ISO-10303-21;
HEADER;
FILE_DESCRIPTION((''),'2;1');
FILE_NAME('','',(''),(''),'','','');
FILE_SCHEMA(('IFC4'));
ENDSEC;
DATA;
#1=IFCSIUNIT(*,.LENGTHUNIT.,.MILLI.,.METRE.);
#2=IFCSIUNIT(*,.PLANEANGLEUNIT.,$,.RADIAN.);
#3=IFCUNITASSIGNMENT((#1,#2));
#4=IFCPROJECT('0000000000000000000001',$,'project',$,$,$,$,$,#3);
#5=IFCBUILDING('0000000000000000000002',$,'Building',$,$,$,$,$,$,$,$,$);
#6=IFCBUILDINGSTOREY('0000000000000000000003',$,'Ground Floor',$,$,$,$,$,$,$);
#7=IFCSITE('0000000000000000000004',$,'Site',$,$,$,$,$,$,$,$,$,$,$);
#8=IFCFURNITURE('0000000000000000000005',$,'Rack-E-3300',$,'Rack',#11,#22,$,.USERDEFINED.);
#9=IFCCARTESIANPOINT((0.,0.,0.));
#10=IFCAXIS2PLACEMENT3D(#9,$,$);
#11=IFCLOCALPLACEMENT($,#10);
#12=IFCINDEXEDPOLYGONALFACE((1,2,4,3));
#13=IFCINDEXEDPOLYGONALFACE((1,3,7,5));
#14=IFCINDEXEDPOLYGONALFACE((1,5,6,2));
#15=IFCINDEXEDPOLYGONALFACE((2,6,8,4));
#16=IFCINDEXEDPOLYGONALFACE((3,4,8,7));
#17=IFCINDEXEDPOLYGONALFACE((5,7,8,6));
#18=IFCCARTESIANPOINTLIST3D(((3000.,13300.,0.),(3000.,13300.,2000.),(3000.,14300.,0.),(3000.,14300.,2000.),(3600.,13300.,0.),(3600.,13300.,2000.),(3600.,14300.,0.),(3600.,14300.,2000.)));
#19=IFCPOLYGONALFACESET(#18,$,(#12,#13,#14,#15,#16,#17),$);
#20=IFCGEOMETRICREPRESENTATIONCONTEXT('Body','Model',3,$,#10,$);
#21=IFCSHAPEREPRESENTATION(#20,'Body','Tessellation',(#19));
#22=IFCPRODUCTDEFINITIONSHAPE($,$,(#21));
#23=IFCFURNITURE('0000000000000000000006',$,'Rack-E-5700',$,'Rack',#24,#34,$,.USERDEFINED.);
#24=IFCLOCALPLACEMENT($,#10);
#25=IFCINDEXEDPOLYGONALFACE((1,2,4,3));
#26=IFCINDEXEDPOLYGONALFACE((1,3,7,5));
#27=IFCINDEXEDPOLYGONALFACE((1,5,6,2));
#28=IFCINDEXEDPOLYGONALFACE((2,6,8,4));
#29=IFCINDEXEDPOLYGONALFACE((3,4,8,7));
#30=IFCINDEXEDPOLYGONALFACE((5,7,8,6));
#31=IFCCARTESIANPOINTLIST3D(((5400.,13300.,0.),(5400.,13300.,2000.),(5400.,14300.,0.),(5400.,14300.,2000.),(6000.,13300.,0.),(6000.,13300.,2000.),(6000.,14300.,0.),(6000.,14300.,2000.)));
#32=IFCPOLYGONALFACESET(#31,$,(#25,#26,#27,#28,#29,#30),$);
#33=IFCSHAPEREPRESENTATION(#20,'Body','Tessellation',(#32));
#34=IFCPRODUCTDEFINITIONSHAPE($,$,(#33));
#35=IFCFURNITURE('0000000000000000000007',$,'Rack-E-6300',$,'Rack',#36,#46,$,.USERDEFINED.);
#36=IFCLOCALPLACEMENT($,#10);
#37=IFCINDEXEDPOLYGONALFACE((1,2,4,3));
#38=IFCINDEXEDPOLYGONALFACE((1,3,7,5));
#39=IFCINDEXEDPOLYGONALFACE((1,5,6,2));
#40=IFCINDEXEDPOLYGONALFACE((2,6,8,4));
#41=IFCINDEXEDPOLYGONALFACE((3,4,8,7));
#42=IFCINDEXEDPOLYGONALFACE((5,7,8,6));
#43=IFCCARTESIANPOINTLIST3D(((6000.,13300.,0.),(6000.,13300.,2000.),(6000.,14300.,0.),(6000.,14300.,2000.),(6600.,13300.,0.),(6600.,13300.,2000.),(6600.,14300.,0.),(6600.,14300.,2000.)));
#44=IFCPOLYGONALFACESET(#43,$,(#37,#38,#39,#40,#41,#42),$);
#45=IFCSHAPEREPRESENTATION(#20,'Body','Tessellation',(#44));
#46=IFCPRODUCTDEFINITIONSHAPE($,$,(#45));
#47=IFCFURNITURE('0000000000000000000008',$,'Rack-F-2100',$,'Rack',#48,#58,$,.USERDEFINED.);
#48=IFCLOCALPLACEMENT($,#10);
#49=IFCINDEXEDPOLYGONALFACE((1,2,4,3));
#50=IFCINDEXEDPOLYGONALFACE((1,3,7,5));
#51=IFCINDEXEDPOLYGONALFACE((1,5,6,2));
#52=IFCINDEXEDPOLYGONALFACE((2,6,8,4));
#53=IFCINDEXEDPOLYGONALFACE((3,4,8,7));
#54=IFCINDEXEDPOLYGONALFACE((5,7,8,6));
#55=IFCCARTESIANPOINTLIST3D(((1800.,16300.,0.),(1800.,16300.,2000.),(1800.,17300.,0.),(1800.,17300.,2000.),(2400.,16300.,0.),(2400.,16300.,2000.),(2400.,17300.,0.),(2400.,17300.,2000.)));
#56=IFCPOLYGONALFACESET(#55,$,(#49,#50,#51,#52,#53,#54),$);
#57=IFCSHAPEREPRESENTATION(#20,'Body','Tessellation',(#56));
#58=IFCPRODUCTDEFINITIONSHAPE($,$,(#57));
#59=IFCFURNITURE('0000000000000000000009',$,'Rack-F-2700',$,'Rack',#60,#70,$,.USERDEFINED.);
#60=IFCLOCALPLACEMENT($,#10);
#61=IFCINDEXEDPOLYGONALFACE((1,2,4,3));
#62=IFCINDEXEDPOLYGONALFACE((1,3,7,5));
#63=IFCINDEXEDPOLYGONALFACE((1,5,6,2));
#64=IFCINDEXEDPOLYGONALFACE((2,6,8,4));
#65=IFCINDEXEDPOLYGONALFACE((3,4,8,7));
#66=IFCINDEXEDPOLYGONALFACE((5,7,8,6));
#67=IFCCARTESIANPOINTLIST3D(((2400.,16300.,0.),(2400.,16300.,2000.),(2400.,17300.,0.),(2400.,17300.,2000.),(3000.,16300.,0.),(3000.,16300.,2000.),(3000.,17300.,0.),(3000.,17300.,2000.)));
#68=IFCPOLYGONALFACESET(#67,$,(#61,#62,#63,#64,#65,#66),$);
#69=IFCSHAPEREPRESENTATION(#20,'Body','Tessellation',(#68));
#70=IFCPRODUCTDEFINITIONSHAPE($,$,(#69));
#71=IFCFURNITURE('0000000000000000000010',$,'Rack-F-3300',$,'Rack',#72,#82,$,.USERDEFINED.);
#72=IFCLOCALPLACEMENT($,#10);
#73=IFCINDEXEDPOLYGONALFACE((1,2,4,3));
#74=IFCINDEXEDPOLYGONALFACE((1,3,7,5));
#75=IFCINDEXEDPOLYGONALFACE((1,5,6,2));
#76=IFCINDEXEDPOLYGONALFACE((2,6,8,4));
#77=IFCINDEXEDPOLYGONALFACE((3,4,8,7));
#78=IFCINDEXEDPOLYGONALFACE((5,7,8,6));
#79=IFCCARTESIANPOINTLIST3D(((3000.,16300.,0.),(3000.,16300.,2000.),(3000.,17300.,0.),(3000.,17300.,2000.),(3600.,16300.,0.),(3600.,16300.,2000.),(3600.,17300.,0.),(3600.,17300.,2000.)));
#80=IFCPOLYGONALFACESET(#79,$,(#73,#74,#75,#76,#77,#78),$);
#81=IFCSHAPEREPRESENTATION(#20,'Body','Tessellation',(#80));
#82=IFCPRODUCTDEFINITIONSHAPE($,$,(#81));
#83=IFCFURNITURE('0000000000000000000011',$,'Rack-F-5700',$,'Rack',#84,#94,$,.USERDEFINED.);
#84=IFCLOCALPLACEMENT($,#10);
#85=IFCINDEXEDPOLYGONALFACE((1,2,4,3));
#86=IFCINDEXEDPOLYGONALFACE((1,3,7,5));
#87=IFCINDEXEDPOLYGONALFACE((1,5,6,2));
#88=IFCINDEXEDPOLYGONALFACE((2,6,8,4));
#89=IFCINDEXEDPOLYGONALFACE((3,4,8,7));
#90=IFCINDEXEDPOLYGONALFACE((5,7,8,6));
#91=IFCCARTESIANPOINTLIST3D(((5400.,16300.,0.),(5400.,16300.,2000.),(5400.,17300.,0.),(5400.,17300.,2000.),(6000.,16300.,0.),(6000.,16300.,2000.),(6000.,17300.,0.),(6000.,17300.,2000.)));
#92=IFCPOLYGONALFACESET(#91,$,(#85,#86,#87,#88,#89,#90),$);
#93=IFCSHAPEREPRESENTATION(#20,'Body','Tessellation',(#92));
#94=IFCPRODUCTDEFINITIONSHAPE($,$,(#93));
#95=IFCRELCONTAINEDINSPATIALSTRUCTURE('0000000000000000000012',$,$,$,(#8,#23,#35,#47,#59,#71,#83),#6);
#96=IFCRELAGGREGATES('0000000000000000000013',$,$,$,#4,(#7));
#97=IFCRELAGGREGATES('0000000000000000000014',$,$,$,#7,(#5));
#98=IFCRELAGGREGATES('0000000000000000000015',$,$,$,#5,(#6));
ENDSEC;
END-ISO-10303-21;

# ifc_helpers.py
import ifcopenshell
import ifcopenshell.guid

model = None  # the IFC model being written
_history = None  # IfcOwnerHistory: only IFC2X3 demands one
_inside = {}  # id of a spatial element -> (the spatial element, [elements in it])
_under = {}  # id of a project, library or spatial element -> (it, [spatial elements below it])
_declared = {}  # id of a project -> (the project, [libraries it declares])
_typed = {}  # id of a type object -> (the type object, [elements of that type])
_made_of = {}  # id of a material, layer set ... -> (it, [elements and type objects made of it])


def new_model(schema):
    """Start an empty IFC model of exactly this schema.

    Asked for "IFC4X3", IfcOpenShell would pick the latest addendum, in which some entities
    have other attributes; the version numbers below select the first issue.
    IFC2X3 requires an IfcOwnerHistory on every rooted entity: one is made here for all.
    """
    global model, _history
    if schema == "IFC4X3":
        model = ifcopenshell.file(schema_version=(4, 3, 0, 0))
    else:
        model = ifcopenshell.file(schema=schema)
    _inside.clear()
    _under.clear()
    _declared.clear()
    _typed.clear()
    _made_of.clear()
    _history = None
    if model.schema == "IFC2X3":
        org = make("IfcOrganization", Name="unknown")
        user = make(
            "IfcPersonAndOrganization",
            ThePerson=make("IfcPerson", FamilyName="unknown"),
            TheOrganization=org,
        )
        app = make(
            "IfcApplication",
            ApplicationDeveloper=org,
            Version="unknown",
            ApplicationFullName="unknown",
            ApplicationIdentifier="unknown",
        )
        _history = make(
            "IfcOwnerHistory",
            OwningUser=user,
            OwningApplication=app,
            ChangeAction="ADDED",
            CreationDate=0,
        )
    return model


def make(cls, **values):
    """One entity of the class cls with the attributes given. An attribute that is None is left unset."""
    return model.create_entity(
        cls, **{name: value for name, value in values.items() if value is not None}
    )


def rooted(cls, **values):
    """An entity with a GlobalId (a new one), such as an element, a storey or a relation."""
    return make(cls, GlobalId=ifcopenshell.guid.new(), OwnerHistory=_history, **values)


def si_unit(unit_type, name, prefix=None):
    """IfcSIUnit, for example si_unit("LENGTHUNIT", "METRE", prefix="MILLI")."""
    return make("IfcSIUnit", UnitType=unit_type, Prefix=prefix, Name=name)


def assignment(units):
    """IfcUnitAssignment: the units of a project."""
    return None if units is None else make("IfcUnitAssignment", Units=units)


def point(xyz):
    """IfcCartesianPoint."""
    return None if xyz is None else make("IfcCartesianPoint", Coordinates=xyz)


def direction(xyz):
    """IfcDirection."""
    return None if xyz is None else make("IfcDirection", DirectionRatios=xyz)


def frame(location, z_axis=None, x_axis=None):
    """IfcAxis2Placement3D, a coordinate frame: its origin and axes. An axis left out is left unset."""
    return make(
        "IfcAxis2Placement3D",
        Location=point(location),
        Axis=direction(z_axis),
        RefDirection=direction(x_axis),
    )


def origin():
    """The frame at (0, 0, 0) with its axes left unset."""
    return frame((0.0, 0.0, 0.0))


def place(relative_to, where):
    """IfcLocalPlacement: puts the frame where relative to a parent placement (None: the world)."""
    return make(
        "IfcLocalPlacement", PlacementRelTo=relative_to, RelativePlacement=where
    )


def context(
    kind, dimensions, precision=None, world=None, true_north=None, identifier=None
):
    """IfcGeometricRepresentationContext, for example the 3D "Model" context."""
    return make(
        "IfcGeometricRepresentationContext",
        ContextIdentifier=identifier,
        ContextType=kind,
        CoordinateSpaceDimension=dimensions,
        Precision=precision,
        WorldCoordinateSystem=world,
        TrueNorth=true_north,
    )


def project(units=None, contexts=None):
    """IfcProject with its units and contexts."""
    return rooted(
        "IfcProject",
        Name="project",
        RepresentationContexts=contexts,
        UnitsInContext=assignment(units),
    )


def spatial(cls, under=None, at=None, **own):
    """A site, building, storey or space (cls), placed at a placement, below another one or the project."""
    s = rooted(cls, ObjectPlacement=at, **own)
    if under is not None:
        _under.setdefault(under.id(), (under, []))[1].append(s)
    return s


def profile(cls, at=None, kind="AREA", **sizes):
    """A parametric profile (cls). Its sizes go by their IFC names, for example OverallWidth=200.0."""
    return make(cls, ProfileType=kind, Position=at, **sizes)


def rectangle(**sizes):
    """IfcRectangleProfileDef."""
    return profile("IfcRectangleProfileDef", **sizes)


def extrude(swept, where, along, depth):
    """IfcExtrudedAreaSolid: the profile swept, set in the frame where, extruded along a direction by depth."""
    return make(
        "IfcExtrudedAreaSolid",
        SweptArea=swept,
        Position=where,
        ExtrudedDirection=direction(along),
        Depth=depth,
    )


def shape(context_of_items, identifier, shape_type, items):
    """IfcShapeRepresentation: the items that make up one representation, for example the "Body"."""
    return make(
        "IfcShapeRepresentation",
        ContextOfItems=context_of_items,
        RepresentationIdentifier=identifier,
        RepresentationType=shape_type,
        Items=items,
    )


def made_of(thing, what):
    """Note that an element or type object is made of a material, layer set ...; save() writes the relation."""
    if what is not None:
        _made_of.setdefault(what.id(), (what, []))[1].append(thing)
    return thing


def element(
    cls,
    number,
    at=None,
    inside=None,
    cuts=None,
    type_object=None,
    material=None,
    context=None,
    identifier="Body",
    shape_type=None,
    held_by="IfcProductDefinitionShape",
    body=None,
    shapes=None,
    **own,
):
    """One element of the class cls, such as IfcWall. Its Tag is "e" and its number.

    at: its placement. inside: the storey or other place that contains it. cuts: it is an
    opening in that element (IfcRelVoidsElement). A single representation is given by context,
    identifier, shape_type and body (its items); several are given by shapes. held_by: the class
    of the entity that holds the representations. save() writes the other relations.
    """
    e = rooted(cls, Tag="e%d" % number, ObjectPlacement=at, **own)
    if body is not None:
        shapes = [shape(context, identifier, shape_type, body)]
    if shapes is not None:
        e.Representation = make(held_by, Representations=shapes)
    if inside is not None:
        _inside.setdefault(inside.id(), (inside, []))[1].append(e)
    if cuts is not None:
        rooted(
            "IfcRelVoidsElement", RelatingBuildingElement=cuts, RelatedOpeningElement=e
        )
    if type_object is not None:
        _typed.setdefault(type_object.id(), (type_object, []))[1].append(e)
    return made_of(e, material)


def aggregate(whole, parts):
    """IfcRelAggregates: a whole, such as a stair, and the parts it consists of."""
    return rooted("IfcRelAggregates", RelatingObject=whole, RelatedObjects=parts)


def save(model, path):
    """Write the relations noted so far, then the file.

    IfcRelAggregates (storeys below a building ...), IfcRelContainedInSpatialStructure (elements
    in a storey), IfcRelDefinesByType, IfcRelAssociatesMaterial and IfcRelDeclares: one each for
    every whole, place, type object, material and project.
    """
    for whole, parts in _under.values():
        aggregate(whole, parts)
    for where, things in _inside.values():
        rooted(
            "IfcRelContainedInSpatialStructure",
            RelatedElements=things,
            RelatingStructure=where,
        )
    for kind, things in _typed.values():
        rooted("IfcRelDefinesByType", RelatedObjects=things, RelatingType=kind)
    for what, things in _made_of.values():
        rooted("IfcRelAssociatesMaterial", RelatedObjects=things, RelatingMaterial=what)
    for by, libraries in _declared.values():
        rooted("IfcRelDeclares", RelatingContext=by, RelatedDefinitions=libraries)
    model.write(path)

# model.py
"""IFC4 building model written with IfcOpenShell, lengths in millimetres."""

from ifc_helpers import new_model, si_unit, frame, origin, place, context, project, spatial, rectangle, extrude, element, save


model = new_model("IFC4")

# Units and contexts
model_context = context("Model", 3, world=origin(), identifier="Body")
ifc_project = project(units=[si_unit("LENGTHUNIT", "METRE", prefix="MILLI"), si_unit("PLANEANGLEUNIT", "RADIAN")])

# Site, building, storey
site = spatial("IfcSite", under=ifc_project, Name="Site")
building = spatial("IfcBuilding", under=site, Name="Building")
storey = spatial("IfcBuildingStorey", under=building, Name="Ground Floor")

# Furniture
for number, where, z_axis, x_axis, name in (
    (1, (3300.0, 13800.0, 0.0), (0.0, 0.0, 1.0), (1.0, 0.0, 0.0), "Rack-E-3300"),
    (2, (5700.0, 13800.0, 0.0), (0.0, 0.0, 1.0), (1.0, 0.0, 0.0), "Rack-E-5700"),
    (3, (6300.0, 13800.0, 0.0), (0.0, 0.0, 1.0), (1.0, 0.0, 0.0), "Rack-E-6300"),
    (4, (2100.0, 16800.0, 0.0), (0.0, 0.0, 1.0), (1.0, 0.0, 0.0), "Rack-F-2100"),
    (5, (2700.0, 16800.0, 0.0), (0.0, 0.0, 1.0), (1.0, 0.0, 0.0), "Rack-F-2700"),
    (6, (3300.0, 16800.0, 0.0), (0.0, 0.0, 1.0), (1.0, 0.0, 0.0), "Rack-F-3300"),
    (7, (5700.0, 16800.0, 0.0), (0.0, 0.0, 1.0), (1.0, 0.0, 0.0), "Rack-F-5700"),
):
    element("IfcFurniture", number, at=place(None, frame(where, z_axis=z_axis, x_axis=x_axis)), inside=storey, Name=name, ObjectType="Rack", PredefinedType="USERDEFINED", context=model_context, shape_type="SweptSolid", body=[
        extrude(rectangle(XDim=600.0, YDim=1000.0), origin(), (0.0, 0.0, 1.0), 2000.0),
    ])

save(model, "model.ifc")
